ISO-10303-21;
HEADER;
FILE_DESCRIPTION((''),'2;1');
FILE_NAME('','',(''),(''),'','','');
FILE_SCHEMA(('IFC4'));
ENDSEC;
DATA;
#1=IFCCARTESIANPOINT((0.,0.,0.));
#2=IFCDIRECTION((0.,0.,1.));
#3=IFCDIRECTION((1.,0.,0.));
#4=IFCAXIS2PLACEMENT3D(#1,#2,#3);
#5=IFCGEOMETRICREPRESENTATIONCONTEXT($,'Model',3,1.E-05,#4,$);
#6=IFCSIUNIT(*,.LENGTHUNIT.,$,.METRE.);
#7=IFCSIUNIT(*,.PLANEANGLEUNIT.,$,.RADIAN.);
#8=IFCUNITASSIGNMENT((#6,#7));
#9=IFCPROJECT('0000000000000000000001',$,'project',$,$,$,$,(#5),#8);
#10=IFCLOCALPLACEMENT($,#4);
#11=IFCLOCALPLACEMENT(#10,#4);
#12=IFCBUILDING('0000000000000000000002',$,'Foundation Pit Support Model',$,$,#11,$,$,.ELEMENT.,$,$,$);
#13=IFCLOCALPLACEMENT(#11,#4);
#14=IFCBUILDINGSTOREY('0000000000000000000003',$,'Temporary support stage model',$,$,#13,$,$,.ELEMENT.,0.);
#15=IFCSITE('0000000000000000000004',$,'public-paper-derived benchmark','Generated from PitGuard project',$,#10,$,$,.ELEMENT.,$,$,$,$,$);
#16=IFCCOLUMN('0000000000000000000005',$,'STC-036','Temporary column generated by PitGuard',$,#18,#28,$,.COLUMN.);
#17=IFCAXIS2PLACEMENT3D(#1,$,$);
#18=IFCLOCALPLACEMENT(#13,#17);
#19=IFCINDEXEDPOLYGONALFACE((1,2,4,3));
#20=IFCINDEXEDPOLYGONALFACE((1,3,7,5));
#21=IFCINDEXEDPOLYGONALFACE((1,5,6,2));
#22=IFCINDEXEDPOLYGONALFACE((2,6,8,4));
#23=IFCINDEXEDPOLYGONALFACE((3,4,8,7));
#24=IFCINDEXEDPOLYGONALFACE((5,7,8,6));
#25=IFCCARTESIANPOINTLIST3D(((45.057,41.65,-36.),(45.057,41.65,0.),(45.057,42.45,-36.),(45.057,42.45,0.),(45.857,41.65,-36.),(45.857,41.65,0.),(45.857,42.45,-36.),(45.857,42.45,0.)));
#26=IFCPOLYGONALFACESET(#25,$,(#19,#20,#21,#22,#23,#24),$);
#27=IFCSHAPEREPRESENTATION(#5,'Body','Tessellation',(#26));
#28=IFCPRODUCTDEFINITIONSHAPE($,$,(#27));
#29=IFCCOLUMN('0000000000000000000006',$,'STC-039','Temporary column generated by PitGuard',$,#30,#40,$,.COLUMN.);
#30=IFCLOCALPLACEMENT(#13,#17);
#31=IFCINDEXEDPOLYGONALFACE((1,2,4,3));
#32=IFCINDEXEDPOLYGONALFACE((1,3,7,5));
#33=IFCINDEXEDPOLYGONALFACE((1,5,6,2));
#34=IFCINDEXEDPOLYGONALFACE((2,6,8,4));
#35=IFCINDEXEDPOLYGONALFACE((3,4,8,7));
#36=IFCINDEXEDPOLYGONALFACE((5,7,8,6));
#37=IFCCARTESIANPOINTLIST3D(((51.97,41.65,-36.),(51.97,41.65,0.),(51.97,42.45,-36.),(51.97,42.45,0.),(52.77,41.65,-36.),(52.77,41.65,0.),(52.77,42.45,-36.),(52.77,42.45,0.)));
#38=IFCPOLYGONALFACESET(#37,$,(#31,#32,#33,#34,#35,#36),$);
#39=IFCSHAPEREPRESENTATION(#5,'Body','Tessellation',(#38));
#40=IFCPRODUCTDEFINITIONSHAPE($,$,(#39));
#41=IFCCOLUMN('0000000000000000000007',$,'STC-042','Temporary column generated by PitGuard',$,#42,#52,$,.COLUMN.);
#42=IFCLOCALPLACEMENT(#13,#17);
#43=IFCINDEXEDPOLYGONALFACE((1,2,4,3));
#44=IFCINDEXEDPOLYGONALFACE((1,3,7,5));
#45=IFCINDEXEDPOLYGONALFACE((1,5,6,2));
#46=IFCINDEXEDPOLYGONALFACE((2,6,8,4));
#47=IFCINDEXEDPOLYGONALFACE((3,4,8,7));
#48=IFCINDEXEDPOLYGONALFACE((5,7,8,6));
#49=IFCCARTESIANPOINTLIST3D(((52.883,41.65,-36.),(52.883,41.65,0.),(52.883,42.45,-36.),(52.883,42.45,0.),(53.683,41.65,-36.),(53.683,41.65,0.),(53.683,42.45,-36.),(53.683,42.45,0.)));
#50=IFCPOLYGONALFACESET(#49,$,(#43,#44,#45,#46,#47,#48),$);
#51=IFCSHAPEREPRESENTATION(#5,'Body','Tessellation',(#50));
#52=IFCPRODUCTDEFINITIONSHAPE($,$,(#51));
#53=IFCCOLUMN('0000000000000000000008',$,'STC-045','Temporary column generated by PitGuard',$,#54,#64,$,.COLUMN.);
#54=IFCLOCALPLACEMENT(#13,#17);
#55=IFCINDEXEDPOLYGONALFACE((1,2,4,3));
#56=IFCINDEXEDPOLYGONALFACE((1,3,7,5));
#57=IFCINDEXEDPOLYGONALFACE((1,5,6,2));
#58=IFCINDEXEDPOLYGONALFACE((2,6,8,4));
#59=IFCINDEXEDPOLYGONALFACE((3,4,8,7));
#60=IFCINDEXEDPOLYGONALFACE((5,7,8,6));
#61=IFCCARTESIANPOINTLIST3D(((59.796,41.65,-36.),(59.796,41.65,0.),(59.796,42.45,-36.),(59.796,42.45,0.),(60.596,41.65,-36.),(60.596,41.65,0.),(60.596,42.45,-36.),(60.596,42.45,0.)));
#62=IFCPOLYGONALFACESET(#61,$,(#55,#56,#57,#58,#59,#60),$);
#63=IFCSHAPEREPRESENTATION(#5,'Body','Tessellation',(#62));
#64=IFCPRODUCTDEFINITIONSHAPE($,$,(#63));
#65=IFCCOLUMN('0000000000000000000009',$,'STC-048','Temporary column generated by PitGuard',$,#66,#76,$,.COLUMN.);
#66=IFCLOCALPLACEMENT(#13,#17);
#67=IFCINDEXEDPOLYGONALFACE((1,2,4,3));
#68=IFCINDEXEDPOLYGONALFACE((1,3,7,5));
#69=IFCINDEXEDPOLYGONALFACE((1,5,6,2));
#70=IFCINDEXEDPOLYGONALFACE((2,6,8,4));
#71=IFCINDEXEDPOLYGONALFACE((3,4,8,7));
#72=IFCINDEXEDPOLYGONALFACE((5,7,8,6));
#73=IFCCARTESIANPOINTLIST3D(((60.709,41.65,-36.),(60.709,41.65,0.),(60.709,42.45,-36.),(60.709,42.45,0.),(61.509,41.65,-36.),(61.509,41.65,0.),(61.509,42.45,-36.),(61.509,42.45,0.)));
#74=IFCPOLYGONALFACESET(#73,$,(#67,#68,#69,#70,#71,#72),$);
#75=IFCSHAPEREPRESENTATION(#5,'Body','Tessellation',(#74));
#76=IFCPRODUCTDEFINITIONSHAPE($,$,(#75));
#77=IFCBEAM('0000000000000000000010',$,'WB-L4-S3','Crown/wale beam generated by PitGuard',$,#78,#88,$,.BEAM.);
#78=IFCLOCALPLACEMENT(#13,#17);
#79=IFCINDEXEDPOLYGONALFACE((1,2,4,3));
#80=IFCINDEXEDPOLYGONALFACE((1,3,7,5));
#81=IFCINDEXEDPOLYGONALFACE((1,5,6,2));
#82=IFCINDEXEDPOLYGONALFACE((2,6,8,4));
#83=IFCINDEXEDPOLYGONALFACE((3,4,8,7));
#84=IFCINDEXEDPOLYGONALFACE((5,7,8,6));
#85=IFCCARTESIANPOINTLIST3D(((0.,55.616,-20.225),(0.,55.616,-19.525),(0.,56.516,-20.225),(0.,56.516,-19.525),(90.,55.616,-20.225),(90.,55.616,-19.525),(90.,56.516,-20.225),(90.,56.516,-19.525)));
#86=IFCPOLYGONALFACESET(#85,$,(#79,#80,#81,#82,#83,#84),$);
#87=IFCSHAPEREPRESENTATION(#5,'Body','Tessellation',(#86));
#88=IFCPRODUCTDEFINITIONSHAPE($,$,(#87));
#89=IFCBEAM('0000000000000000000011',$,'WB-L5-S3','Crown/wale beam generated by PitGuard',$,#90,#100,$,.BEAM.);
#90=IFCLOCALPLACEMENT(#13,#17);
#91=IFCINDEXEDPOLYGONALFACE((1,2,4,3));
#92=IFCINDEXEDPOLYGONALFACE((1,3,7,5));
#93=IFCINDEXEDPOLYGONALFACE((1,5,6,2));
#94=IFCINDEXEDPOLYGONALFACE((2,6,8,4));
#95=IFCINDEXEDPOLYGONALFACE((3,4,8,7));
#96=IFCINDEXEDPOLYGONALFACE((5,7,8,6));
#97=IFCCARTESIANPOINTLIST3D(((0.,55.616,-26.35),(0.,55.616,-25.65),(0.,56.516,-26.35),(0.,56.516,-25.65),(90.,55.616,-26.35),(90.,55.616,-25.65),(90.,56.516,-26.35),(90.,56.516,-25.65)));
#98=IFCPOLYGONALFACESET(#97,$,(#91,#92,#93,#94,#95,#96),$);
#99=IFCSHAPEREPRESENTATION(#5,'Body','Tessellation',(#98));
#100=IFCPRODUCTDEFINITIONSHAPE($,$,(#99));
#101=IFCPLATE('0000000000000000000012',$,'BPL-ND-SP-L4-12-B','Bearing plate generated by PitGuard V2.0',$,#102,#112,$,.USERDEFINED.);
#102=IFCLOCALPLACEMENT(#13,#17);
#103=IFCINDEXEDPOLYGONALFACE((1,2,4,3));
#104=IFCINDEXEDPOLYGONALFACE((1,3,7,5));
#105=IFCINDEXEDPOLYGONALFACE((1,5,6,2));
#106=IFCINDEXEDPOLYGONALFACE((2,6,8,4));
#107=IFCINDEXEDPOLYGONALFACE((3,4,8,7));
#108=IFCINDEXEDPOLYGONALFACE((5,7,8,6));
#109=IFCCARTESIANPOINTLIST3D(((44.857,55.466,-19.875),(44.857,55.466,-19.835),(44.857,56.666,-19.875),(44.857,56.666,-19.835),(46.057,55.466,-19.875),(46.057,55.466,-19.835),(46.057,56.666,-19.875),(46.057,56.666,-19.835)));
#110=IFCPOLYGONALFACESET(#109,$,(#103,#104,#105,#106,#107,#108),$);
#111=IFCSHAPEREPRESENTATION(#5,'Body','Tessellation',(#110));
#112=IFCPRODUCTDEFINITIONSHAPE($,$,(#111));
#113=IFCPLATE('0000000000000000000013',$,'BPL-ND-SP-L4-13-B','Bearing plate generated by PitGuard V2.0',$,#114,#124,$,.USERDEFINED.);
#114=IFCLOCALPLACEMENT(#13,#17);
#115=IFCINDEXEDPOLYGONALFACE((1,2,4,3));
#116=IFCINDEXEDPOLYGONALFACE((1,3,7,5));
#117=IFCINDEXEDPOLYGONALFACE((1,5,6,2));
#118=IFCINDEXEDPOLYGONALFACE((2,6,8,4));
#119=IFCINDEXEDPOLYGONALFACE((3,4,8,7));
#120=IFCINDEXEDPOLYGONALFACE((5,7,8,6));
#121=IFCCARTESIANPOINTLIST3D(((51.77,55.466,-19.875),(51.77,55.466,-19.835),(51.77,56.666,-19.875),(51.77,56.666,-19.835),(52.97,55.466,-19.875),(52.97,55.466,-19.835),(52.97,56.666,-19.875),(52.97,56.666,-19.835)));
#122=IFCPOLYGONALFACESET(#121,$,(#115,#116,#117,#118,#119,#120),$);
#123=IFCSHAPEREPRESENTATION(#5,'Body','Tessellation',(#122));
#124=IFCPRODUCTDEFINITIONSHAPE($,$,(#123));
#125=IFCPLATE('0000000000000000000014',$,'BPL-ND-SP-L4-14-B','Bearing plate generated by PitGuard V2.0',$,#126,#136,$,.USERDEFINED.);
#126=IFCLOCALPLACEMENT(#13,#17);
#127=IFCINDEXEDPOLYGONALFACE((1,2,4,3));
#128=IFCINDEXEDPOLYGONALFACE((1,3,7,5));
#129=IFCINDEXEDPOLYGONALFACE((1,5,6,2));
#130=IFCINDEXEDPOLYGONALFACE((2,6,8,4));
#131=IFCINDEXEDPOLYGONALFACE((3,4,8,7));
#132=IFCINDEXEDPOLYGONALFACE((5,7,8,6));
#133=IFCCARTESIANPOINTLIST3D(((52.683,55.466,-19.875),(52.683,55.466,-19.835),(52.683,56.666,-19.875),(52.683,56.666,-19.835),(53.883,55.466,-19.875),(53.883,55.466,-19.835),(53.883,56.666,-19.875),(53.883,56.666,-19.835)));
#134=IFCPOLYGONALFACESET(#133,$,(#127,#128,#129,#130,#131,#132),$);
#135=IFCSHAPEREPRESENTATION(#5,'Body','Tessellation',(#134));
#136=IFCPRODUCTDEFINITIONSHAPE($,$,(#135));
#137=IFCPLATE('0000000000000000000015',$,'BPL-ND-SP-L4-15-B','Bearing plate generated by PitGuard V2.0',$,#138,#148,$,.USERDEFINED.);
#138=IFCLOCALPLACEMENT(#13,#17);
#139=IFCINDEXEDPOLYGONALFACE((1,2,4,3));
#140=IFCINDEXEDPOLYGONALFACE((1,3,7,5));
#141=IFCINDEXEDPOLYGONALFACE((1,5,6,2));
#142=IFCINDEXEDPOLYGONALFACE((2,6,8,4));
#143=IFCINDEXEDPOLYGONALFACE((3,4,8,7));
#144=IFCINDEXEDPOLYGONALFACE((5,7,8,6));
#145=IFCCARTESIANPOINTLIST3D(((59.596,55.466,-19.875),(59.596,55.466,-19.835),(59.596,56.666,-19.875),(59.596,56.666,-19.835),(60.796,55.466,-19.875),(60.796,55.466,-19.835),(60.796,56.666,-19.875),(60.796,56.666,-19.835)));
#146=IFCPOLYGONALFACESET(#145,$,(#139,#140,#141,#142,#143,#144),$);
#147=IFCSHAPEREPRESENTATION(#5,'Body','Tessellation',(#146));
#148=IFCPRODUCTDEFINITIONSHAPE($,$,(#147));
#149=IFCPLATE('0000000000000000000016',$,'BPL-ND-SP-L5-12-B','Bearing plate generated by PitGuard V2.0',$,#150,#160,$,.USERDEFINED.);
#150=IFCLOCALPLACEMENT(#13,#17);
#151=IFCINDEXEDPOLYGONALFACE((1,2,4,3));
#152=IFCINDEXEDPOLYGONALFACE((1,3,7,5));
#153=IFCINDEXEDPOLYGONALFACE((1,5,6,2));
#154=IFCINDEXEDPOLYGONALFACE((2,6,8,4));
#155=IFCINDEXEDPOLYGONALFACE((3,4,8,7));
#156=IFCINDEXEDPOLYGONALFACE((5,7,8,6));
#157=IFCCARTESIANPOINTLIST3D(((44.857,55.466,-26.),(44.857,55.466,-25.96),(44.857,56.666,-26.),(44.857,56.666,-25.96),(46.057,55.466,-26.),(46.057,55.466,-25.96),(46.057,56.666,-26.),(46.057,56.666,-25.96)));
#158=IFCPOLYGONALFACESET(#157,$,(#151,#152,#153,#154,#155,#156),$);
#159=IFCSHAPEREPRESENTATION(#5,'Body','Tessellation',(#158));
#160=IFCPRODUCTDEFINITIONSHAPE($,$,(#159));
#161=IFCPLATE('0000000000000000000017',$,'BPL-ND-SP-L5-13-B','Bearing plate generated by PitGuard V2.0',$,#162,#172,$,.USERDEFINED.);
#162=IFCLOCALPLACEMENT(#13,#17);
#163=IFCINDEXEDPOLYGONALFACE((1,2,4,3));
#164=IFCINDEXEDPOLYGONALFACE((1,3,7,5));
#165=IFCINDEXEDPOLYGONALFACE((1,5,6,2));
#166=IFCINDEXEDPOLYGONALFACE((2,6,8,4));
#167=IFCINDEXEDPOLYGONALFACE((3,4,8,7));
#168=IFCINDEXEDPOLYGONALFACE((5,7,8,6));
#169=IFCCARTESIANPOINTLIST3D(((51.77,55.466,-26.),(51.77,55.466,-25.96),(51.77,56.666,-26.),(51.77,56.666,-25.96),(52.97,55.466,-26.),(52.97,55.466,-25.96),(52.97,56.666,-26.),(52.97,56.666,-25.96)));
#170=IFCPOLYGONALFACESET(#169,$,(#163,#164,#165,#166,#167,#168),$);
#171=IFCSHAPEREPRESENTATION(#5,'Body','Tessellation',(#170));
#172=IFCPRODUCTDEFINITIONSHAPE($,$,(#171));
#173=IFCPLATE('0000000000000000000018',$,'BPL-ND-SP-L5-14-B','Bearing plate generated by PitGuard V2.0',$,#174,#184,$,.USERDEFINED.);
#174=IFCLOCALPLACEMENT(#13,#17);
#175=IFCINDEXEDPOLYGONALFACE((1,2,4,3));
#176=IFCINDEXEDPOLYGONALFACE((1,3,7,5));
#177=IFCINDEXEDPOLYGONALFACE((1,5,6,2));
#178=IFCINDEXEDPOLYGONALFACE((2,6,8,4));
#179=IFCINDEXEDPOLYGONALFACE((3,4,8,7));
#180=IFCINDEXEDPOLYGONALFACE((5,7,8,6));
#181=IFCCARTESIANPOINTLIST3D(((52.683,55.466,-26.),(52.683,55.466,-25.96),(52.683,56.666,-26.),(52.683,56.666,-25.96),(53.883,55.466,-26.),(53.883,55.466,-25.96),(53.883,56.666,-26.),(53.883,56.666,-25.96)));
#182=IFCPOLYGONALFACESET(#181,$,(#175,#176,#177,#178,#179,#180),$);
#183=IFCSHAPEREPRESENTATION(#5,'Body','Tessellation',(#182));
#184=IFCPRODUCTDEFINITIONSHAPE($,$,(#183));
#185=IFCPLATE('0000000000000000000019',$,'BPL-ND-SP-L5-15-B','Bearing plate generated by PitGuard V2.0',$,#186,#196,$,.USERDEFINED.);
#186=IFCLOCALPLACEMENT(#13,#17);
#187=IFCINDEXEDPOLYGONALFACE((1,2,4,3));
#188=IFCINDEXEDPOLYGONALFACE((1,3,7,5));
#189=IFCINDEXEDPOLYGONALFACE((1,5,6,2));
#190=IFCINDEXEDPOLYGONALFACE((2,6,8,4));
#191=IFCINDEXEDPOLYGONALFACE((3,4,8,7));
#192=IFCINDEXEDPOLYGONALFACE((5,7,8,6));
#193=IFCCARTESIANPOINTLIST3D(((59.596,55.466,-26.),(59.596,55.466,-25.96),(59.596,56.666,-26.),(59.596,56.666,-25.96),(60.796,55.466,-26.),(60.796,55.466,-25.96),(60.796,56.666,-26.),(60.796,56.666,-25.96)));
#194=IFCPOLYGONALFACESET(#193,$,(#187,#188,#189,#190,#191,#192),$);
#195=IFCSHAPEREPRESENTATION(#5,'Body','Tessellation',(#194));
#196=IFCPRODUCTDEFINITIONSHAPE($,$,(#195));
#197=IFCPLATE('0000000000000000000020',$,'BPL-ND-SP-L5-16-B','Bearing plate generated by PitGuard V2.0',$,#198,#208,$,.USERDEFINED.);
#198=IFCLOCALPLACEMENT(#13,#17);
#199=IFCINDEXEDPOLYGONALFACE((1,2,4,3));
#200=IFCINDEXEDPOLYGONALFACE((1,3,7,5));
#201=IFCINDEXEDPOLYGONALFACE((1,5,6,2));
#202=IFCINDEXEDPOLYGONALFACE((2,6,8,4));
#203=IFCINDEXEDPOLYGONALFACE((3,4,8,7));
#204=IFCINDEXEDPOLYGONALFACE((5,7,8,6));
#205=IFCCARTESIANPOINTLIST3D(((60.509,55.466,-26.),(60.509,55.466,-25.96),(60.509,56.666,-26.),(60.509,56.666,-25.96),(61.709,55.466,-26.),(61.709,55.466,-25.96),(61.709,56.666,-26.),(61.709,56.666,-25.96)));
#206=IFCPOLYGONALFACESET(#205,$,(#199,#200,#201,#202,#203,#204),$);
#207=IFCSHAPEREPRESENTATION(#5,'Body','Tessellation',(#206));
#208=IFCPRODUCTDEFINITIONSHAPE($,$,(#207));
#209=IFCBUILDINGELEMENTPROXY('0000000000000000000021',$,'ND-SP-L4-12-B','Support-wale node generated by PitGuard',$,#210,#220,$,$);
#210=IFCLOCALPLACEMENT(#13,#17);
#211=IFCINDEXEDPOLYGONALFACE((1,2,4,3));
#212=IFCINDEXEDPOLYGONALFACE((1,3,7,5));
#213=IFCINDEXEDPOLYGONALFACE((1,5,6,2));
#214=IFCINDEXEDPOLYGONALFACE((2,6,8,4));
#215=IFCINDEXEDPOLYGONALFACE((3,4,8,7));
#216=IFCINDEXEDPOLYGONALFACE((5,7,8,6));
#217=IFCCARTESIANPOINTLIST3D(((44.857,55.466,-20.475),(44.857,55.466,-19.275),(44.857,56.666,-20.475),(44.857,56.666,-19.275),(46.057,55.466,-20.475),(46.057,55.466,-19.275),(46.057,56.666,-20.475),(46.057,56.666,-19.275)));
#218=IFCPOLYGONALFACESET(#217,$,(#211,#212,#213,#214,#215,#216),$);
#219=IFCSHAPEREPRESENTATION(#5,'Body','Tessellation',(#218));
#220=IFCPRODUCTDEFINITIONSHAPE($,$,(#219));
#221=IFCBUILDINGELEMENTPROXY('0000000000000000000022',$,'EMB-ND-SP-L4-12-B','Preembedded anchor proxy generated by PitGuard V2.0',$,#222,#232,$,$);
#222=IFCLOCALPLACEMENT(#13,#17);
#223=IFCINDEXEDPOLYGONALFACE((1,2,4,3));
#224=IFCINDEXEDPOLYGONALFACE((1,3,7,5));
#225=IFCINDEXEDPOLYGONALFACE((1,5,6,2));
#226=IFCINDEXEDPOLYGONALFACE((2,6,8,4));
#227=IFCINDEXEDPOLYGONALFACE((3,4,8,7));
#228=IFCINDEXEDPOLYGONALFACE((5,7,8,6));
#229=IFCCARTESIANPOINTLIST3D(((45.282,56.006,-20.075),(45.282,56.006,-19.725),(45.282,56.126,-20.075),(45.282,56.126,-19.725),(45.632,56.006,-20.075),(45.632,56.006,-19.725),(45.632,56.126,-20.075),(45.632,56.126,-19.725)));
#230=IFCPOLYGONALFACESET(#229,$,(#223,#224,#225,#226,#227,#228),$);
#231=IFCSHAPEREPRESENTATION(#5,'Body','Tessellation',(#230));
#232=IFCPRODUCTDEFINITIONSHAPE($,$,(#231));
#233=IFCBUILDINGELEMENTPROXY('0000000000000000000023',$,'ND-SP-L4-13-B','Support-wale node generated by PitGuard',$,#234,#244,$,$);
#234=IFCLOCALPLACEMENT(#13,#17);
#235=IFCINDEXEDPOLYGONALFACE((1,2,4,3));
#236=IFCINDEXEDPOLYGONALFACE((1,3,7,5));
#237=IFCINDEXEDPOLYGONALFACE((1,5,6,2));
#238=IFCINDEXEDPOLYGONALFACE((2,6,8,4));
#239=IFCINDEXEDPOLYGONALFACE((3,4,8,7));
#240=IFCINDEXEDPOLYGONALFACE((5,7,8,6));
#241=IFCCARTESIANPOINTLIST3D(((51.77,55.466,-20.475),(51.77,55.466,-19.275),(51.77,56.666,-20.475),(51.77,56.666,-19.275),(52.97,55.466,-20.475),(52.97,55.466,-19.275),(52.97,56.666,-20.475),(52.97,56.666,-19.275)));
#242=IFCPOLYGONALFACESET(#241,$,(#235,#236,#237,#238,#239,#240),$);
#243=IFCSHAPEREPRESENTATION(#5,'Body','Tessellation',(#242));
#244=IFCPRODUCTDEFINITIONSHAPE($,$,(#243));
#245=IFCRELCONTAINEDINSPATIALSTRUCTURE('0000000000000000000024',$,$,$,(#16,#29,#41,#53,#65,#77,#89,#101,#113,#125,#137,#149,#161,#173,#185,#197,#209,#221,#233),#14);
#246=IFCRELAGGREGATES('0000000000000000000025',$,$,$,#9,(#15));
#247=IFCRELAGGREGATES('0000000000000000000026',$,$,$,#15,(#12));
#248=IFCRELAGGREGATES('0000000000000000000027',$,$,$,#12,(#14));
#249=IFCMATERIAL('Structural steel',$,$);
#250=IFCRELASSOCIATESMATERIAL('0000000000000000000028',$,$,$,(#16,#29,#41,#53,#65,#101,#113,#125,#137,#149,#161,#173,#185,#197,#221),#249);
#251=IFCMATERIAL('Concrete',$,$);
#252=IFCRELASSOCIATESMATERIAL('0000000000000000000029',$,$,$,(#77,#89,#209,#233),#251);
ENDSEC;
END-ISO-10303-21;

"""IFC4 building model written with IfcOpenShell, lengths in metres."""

from ifc_helpers import new_model, si_unit, frame, origin_with_axes, origin_2d, place, context, project, spatial, rectangle, extrude, material, element, save


model = new_model("IFC4")

# Units and contexts
model_context = context("Model", 3, precision=1e-05, world=origin_with_axes())
ifc_project = project(units=[si_unit("LENGTHUNIT", "METRE"), si_unit("PLANEANGLEUNIT", "RADIAN")], contexts=[model_context])

# Site, building, storey
site_placement = place(None, origin_with_axes())
site = spatial("IfcSite", under=ifc_project, at=site_placement, Name="public-paper-derived benchmark", Description="Generated from PitGuard project", CompositionType="ELEMENT")
building_placement = place(site_placement, origin_with_axes())
building = spatial("IfcBuilding", under=site, at=building_placement, Name="Foundation Pit Support Model", CompositionType="ELEMENT")
storey_placement = place(building_placement, origin_with_axes())
storey = spatial("IfcBuildingStorey", under=building, at=storey_placement, Name="Temporary support stage model", CompositionType="ELEMENT", Elevation=0.0)

# Columns
ifc_material_1 = material(Name="Structural steel")
for number, where, z_axis, x_axis, name in (
    (1, (45.457, 42.05, -36.0), (0.0, 0.0, 1.0), (1.0, 0.0, 0.0), "STC-036"),
    (2, (52.37, 42.05, -36.0), (0.0, 0.0, 1.0), (1.0, 0.0, 0.0), "STC-039"),
    (3, (53.283, 42.05, -36.0), (0.0, 0.0, 1.0), (1.0, 0.0, 0.0), "STC-042"),
    (4, (60.196, 42.05, -36.0), (0.0, 0.0, 1.0), (1.0, 0.0, 0.0), "STC-045"),
    (5, (61.109, 42.05, -36.0), (0.0, 0.0, 1.0), (1.0, 0.0, 0.0), "STC-048"),
):
    element("IfcColumn", number, at=place(storey_placement, frame(where, z_axis=z_axis, x_axis=x_axis)), inside=storey, material=ifc_material_1, Name=name, Description="Temporary column generated by PitGuard", PredefinedType="COLUMN", context=model_context, shape_type="SweptSolid", body=[
        extrude(rectangle(XDim=0.8, YDim=0.8, at=origin_2d()), origin_with_axes(), (0.0, 0.0, 1.0), 36.0),
    ])

# Beams
ifc_material_2 = material(Name="Concrete")
for number, where, z_axis, x_axis, name in (
    (6, (45.0, 56.066, -20.225), (0.0, 0.0, 1.0), (-1.0, 0.0, 0.0), "WB-L4-S3"),
    (7, (45.0, 56.066, -26.35), (0.0, 0.0, 1.0), (-1.0, 0.0, 0.0), "WB-L5-S3"),
):
    element("IfcBeam", number, at=place(storey_placement, frame(where, z_axis=z_axis, x_axis=x_axis)), inside=storey, material=ifc_material_2, Name=name, Description="Crown/wale beam generated by PitGuard", PredefinedType="BEAM", context=model_context, shape_type="SweptSolid", body=[
        extrude(rectangle(XDim=90.0, YDim=0.9, at=origin_2d()), origin_with_axes(), (0.0, 0.0, 1.0), 0.7),
    ])

# Plates
for number, where, z_axis, x_axis, name in (
    (8, (45.457, 56.066, -19.875), (0.0, 0.0, 1.0), (1.0, 0.0, 0.0), "BPL-ND-SP-L4-12-B"),
    (9, (52.37, 56.066, -19.875), (0.0, 0.0, 1.0), (1.0, 0.0, 0.0), "BPL-ND-SP-L4-13-B"),
    (10, (53.283, 56.066, -19.875), (0.0, 0.0, 1.0), (1.0, 0.0, 0.0), "BPL-ND-SP-L4-14-B"),
    (11, (60.196, 56.066, -19.875), (0.0, 0.0, 1.0), (1.0, 0.0, 0.0), "BPL-ND-SP-L4-15-B"),
    (12, (45.457, 56.066, -26.0), (0.0, 0.0, 1.0), (1.0, 0.0, 0.0), "BPL-ND-SP-L5-12-B"),
    (13, (52.37, 56.066, -26.0), (0.0, 0.0, 1.0), (1.0, 0.0, 0.0), "BPL-ND-SP-L5-13-B"),
    (14, (53.283, 56.066, -26.0), (0.0, 0.0, 1.0), (1.0, 0.0, 0.0), "BPL-ND-SP-L5-14-B"),
    (15, (60.196, 56.066, -26.0), (0.0, 0.0, 1.0), (1.0, 0.0, 0.0), "BPL-ND-SP-L5-15-B"),
    (16, (61.109, 56.066, -26.0), (0.0, 0.0, 1.0), (1.0, 0.0, 0.0), "BPL-ND-SP-L5-16-B"),
):
    element("IfcPlate", number, at=place(storey_placement, frame(where, z_axis=z_axis, x_axis=x_axis)), inside=storey, material=ifc_material_1, Name=name, Description="Bearing plate generated by PitGuard V2.0", PredefinedType="USERDEFINED", context=model_context, shape_type="SweptSolid", body=[
        extrude(rectangle(XDim=1.2, YDim=1.2, at=origin_2d()), origin_with_axes(), (0.0, 0.0, 1.0), 0.04),
    ])

# Building element proxies
proxy_1_placement = place(storey_placement, frame((45.457, 56.066, -20.475), z_axis=(0.0, 0.0, 1.0), x_axis=(1.0, 0.0, 0.0)))
element("IfcBuildingElementProxy", 17, at=proxy_1_placement, inside=storey, material=ifc_material_2, Name="ND-SP-L4-12-B", Description="Support-wale node generated by PitGuard", context=model_context, shape_type="SweptSolid", body=[
    extrude(rectangle(XDim=1.2, YDim=1.2, at=origin_2d()), origin_with_axes(), (0.0, 0.0, 1.0), 1.2),
])
proxy_2_placement = place(storey_placement, frame((45.457, 56.066, -20.075), z_axis=(0.0, 0.0, 1.0), x_axis=(1.0, 0.0, 0.0)))
element("IfcBuildingElementProxy", 18, at=proxy_2_placement, inside=storey, material=ifc_material_1, Name="EMB-ND-SP-L4-12-B", Description="Preembedded anchor proxy generated by PitGuard V2.0", context=model_context, shape_type="SweptSolid", body=[
    extrude(rectangle(XDim=0.35, YDim=0.12, at=origin_2d()), origin_with_axes(), (0.0, 0.0, 1.0), 0.35),
])
proxy_3_placement = place(storey_placement, frame((52.37, 56.066, -20.475), z_axis=(0.0, 0.0, 1.0), x_axis=(1.0, 0.0, 0.0)))
element("IfcBuildingElementProxy", 19, at=proxy_3_placement, inside=storey, material=ifc_material_2, Name="ND-SP-L4-13-B", Description="Support-wale node generated by PitGuard", context=model_context, shape_type="SweptSolid", body=[
    extrude(rectangle(XDim=1.2, YDim=1.2, at=origin_2d()), origin_with_axes(), (0.0, 0.0, 1.0), 1.2),
])

save(model, "model.ifc")
